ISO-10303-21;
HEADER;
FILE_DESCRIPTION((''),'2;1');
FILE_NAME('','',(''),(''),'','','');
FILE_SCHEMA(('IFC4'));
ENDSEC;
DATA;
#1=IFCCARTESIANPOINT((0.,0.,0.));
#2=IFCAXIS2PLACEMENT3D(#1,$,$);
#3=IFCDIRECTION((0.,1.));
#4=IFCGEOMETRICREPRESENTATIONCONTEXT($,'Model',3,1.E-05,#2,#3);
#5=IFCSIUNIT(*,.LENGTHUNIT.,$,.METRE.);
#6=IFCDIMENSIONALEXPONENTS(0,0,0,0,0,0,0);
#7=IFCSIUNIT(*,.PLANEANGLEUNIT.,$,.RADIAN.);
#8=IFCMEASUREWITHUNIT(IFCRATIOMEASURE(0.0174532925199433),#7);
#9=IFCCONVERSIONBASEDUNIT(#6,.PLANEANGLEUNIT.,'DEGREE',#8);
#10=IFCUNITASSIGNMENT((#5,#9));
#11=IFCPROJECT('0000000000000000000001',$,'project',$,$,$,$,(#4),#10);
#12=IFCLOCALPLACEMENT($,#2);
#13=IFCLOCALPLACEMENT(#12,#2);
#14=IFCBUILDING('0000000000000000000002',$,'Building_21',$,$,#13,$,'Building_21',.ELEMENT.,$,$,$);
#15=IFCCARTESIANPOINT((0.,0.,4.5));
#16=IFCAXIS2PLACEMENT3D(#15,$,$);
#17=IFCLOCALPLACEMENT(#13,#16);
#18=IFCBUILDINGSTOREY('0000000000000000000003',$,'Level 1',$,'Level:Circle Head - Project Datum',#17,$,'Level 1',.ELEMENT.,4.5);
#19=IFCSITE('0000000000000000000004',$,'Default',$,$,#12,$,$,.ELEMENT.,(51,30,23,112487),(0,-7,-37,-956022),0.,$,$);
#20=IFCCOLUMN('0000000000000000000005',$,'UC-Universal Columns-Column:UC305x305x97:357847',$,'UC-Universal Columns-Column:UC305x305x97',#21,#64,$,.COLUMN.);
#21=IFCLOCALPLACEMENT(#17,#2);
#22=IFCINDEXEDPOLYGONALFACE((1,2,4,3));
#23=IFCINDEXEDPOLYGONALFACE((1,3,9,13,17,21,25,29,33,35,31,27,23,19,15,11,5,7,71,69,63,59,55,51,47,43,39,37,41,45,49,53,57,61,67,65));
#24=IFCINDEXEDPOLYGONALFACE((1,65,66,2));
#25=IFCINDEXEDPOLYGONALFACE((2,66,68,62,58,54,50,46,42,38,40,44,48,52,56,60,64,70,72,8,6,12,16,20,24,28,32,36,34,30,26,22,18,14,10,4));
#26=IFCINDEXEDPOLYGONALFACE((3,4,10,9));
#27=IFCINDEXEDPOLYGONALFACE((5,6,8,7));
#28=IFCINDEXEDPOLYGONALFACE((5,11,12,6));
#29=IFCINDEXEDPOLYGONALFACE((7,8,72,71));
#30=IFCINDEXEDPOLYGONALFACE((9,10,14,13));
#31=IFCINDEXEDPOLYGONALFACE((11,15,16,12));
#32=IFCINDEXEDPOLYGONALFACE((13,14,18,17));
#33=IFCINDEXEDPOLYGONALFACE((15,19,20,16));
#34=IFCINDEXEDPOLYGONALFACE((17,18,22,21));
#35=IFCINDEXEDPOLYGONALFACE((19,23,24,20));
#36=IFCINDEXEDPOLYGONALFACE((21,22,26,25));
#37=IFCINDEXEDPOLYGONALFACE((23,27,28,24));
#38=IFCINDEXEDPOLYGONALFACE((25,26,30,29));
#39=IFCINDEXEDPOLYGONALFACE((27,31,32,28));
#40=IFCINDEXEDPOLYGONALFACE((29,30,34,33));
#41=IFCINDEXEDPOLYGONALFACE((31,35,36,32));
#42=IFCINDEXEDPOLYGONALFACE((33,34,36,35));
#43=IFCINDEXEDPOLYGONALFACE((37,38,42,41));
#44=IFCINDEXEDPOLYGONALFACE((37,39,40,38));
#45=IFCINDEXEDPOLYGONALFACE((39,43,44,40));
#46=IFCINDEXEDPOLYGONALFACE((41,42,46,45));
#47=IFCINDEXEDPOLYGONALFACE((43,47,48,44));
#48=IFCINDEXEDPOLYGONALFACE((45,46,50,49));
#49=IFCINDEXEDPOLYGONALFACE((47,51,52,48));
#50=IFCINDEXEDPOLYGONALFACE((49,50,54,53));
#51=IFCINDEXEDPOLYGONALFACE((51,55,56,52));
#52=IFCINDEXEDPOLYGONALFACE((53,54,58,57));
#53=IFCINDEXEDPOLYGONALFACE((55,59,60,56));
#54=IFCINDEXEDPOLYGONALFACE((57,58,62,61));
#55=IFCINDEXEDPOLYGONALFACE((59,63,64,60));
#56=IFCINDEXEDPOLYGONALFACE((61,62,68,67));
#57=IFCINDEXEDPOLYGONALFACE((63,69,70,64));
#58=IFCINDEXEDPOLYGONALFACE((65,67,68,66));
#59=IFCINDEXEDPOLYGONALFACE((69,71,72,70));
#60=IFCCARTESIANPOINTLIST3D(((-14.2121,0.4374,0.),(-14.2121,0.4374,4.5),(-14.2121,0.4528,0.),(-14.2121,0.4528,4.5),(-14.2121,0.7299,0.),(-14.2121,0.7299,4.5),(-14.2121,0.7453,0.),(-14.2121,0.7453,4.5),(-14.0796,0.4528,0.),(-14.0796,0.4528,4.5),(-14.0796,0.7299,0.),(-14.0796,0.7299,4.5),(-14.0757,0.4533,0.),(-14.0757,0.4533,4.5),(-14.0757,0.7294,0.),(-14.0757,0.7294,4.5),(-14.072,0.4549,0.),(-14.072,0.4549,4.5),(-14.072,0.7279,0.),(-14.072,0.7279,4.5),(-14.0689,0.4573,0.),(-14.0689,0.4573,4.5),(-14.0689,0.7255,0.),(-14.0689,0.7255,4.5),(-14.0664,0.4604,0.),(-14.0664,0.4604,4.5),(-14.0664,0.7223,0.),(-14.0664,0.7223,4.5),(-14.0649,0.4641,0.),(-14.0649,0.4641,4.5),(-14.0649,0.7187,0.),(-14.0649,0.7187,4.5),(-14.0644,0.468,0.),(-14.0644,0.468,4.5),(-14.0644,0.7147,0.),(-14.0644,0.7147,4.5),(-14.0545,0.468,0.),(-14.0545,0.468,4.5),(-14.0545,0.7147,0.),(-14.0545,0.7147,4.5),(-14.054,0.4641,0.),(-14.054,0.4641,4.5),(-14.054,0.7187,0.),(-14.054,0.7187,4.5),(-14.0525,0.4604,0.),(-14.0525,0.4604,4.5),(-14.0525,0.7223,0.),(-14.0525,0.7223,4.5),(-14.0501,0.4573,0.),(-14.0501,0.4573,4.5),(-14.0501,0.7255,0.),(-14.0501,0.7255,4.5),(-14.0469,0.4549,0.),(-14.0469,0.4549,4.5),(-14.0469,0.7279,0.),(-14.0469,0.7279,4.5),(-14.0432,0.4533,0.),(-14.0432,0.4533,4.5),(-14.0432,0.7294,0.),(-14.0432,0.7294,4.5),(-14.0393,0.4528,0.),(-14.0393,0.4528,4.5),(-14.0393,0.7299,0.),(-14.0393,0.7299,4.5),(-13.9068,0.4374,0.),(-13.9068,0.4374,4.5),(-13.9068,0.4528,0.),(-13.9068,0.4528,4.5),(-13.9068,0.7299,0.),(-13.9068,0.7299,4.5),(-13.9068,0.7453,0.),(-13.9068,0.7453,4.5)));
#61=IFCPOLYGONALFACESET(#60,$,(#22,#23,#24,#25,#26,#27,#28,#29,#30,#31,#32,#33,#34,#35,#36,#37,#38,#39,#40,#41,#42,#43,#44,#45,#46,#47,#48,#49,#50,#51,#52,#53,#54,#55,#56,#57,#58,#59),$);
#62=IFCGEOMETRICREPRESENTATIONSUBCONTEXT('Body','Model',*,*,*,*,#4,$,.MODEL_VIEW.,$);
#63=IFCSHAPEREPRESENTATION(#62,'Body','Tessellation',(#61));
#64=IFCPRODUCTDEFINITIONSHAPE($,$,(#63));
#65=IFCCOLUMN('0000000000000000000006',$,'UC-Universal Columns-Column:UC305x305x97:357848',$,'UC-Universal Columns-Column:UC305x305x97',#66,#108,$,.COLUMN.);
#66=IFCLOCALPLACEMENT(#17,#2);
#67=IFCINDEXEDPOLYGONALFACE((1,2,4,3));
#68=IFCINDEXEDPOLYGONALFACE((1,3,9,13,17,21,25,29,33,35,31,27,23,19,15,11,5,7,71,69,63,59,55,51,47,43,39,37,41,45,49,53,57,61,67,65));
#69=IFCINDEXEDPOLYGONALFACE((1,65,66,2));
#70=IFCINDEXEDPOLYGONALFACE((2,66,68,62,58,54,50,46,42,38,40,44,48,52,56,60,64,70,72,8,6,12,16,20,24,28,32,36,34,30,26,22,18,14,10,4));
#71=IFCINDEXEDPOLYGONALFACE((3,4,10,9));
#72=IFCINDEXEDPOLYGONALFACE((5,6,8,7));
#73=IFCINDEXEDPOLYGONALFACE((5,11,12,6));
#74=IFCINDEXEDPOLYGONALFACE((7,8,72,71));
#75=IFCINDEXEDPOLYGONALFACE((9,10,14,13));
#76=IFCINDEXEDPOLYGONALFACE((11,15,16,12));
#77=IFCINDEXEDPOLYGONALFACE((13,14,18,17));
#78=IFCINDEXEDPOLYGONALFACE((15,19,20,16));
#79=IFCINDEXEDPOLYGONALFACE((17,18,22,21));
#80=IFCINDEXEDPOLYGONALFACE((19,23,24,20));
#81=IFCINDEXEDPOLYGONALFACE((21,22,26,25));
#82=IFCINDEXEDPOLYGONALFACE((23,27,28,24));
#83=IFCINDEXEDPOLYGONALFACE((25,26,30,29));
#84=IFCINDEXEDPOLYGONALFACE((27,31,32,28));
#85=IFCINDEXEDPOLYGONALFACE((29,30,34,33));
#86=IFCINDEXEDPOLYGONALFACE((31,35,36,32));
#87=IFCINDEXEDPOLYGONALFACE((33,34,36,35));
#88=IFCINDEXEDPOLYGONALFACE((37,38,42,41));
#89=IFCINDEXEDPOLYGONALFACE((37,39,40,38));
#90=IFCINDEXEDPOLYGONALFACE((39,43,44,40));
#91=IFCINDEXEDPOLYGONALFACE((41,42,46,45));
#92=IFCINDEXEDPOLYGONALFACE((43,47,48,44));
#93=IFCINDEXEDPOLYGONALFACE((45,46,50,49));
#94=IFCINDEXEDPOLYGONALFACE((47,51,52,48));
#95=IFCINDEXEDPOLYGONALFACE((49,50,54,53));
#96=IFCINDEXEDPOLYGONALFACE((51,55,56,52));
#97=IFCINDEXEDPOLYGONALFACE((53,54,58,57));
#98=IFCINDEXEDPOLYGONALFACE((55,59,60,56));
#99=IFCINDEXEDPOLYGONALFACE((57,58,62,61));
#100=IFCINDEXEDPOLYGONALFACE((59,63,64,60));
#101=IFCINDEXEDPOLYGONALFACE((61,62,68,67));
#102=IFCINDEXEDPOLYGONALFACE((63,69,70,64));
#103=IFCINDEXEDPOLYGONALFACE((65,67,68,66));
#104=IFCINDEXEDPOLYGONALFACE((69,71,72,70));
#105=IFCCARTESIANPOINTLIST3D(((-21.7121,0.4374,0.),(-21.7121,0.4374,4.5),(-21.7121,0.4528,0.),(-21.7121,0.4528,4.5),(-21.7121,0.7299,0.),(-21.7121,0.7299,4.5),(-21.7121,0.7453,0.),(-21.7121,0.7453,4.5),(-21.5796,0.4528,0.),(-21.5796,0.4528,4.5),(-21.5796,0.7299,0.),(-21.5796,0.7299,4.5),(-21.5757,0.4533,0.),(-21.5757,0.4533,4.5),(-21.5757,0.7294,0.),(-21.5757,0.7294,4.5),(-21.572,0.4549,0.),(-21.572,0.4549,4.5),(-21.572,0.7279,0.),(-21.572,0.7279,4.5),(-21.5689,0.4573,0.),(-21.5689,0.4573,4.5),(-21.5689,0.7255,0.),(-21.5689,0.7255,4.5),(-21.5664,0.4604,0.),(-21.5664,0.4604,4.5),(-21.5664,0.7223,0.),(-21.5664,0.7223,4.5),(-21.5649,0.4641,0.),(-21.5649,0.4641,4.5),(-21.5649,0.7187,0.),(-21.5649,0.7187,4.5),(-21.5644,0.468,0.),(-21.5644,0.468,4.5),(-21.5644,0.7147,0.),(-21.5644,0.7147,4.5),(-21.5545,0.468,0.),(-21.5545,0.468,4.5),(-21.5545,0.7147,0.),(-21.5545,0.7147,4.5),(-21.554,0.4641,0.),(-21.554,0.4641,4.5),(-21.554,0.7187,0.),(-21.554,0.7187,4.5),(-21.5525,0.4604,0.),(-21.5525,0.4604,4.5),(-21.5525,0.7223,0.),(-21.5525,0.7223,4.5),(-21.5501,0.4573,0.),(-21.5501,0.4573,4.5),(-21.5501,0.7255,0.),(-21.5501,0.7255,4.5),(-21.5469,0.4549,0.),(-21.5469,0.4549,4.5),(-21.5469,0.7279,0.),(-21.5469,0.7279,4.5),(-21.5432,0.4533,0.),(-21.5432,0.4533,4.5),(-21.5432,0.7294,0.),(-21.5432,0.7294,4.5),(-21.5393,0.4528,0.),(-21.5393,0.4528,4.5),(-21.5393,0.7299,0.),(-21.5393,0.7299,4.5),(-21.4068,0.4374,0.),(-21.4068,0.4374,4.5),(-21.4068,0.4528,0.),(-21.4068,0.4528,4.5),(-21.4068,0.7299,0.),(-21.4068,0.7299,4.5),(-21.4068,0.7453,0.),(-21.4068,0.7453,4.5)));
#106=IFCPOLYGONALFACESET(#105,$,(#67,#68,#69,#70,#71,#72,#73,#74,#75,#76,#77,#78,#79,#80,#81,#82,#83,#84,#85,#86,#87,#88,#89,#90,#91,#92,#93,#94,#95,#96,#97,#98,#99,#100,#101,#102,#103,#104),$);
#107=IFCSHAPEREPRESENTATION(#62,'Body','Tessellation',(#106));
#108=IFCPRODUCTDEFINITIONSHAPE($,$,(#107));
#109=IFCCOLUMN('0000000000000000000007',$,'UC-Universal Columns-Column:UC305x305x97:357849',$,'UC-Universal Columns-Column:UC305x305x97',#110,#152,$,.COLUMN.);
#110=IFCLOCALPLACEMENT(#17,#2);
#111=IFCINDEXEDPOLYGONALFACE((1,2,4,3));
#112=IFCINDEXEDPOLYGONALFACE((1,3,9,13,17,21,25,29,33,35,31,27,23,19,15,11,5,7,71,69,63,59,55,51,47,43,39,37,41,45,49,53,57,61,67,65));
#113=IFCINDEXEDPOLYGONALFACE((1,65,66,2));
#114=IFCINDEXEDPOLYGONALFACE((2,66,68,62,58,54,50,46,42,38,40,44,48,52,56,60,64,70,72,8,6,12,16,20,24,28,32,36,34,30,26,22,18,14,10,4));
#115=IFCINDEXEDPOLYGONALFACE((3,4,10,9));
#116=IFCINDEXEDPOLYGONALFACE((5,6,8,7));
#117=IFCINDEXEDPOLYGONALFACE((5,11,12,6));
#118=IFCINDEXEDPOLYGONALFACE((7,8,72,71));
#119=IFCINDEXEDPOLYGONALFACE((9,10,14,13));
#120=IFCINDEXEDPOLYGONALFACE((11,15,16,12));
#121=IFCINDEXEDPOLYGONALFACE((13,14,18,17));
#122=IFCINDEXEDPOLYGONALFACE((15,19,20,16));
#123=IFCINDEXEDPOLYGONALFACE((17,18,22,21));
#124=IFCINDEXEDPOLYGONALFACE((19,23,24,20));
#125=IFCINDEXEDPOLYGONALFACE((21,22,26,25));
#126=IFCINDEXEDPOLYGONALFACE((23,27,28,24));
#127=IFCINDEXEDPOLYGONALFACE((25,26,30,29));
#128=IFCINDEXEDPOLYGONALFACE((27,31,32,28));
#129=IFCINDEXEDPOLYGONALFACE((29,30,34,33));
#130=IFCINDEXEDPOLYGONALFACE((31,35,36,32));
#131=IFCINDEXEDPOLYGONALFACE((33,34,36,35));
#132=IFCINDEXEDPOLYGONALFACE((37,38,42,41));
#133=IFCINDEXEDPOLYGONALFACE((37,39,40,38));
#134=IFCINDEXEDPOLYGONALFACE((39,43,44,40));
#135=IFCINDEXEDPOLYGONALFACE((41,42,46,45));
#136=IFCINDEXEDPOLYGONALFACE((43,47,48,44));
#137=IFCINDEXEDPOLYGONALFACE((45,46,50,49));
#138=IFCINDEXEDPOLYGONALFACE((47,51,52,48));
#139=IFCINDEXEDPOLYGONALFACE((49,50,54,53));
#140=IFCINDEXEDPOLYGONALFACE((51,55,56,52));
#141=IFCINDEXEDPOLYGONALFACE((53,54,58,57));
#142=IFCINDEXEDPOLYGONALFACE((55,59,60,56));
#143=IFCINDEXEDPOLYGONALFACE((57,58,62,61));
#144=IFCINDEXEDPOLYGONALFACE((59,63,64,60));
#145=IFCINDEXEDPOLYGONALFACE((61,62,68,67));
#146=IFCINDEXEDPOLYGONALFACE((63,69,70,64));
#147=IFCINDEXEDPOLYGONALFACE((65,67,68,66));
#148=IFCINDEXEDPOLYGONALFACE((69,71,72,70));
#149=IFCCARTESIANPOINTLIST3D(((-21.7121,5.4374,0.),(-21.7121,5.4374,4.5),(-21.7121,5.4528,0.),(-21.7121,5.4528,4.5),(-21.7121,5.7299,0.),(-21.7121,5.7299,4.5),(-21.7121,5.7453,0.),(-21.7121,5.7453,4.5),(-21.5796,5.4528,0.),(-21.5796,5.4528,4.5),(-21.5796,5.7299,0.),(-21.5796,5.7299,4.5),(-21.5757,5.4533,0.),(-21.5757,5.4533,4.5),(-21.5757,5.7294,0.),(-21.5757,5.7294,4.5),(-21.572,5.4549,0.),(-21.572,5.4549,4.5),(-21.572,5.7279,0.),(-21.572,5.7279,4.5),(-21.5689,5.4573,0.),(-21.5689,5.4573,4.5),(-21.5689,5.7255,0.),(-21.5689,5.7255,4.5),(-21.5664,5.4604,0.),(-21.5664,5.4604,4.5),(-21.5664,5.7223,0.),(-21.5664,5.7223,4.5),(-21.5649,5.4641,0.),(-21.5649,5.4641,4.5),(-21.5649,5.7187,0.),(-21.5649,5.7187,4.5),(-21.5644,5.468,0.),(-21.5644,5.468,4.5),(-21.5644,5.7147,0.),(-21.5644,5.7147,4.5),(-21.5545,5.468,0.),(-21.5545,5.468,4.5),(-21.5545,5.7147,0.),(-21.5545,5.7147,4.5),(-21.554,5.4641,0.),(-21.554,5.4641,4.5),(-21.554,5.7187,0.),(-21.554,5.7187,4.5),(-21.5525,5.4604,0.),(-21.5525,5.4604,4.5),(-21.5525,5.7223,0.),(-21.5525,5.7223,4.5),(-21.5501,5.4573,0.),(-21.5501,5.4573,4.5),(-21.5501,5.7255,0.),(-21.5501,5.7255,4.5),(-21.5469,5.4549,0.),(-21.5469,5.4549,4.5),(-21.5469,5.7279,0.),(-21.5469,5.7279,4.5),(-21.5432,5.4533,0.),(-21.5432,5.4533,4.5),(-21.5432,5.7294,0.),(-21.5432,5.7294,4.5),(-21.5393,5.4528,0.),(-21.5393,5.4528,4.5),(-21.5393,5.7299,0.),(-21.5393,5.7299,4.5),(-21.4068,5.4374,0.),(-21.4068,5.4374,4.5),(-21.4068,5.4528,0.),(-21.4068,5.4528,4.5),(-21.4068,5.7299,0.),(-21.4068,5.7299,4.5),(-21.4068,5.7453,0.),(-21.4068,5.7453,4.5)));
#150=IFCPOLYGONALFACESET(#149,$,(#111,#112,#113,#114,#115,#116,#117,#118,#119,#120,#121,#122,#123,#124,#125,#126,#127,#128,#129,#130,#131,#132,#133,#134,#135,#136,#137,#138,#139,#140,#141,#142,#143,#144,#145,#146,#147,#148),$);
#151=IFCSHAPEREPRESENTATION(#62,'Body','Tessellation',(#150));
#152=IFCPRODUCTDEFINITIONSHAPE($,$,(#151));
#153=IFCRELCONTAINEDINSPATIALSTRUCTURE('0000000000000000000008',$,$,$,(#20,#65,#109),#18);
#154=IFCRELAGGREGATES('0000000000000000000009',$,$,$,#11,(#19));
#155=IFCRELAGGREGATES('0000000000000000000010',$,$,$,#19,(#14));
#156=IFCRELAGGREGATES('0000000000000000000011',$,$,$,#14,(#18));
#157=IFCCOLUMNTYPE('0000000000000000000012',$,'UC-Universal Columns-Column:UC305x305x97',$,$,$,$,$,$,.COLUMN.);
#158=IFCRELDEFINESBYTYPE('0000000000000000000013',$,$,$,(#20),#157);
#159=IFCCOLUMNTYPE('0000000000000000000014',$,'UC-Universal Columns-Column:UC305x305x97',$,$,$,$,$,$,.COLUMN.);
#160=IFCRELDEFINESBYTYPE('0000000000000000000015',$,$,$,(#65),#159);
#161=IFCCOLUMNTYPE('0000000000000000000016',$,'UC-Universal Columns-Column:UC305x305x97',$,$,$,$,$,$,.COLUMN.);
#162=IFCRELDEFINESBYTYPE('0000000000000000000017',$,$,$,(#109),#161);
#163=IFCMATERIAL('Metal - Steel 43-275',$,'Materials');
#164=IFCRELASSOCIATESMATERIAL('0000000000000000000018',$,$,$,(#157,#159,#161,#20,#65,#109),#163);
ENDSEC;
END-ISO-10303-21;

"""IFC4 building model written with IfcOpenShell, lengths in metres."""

from ifc_helpers import new_model, entity, si_unit, converted_unit, direction, frame, frame_2d, origin, place, context, subcontext, project, spatial, polyline, circle_curve, parameter, trimmed, segment, composite_curve, i_section, outline, extrude, source, transform, mapped, material, material_profile, profile_set, profile_usage, type_object, type_shapes, element, save


model = new_model("IFC4")

# Units and contexts
model_context = context("Model", 3, precision=1e-05, world=origin(), true_north=direction((0.0, 1.0)))
body_context = subcontext(model_context, "Body", "Model", "MODEL_VIEW")
ifc_project = project(units=[si_unit("LENGTHUNIT", "METRE"), converted_unit("PLANEANGLEUNIT", "DEGREE", entity("IfcRatioMeasure", 0.0174532925199433), si_unit("PLANEANGLEUNIT", "RADIAN"), dimensions=[0, 0, 0, 0, 0, 0, 0])], contexts=[model_context])

# Site, building, storey
site_placement = place(None, origin())
site = spatial("IfcSite", under=ifc_project, at=site_placement, Name="Default", CompositionType="ELEMENT", RefLatitude=(51, 30, 23, 112487), RefLongitude=(0, -7, -37, -956022), RefElevation=0.0)
building_placement = place(site_placement, origin())
building = spatial("IfcBuilding", under=site, at=building_placement, Name="Building_21", LongName="Building_21", CompositionType="ELEMENT")
storey_placement = place(building_placement, frame((0.0, 0.0, 4.5)))
storey = spatial("IfcBuildingStorey", under=building, at=storey_placement, Name="Level 1", ObjectType="Level:Circle Head - Project Datum", LongName="Level 1", CompositionType="ELEMENT", Elevation=4.5)

# Columns
ifc_material_1 = material(Name="Metal - Steel 43-275", Category="Materials")
ifc_material_profile_1 = material_profile(ifc_material_1, outline(composite_curve([segment(polyline([(-0.1527, 0.154, 0.0), (0.1527, 0.154, 0.0)]), True, "CONTINUOUS"), segment(polyline([(0.1527, 0.154, 0.0), (0.1527, 0.1386, 0.0)]), True, "CONTINUOUS"), segment(polyline([(0.1527, 0.1386, 0.0), (0.0201, 0.1386, 0.0)]), True, "CONTINUOUS"), segment(trimmed(circle_curve(frame((0.0201, 0.1234, 0.0)), 0.0152), [parameter(90.0)], [parameter(180.0)], True, "PARAMETER"), True, "CONTINUOUS"), segment(polyline([(0.0049, 0.1234, 0.0), (0.0049, -0.1234, 0.0)]), True, "CONTINUOUS"), segment(trimmed(circle_curve(frame((0.0201, -0.1234, 0.0)), 0.0152), [parameter(180.0)], [parameter(270.0)], True, "PARAMETER"), True, "CONTINUOUS"), segment(polyline([(0.0201, -0.1386, 0.0), (0.1527, -0.1386, 0.0)]), True, "CONTINUOUS"), segment(polyline([(0.1527, -0.1386, 0.0), (0.1527, -0.154, 0.0)]), True, "CONTINUOUS"), segment(polyline([(0.1527, -0.154, 0.0), (-0.1527, -0.154, 0.0)]), True, "CONTINUOUS"), segment(polyline([(-0.1527, -0.154, 0.0), (-0.1527, -0.1386, 0.0)]), True, "CONTINUOUS"), segment(polyline([(-0.1527, -0.1386, 0.0), (-0.0201, -0.1386, 0.0)]), True, "CONTINUOUS"), segment(trimmed(circle_curve(frame((-0.0201, -0.1234, 0.0)), 0.0152), [parameter(270.0)], [parameter(0.0)], True, "PARAMETER"), True, "CONTINUOUS"), segment(polyline([(-0.0049, -0.1234, 0.0), (-0.005, 0.1234, 0.0)]), True, "CONTINUOUS"), segment(trimmed(circle_curve(frame((-0.0201, 0.1234, 0.0)), 0.0152), [parameter(0.0)], [parameter(90.0)], True, "PARAMETER"), True, "CONTINUOUS"), segment(polyline([(-0.0201, 0.1386, 0.0), (-0.1527, 0.1386, 0.0)]), True, "CONTINUOUS"), segment(polyline([(-0.1527, 0.1386, 0.0), (-0.1527, 0.154, 0.0)]), True, "CONTINUOUS")], self_intersect=False), kind="CURVE"), Name="UC305x305x97")
ifc_material_profile_2 = material_profile(ifc_material_1, outline(composite_curve([segment(polyline([(0.1527, 0.154, 0.0), (0.1527, 0.1386, 0.0)]), True, "CONTINUOUS"), segment(polyline([(0.1527, 0.1386, 0.0), (0.0049, 0.1386, 0.0)]), True, "CONTINUOUS"), segment(polyline([(0.0049, 0.1386, 0.0), (0.0049, -0.1386, 0.0)]), True, "CONTINUOUS"), segment(polyline([(0.0049, -0.1386, 0.0), (0.1527, -0.1386, 0.0)]), True, "CONTINUOUS"), segment(polyline([(0.1527, -0.1386, 0.0), (0.1527, -0.154, 0.0)]), True, "CONTINUOUS"), segment(polyline([(0.1527, -0.154, 0.0), (-0.1527, -0.154, 0.0)]), True, "CONTINUOUS"), segment(polyline([(-0.1527, -0.154, 0.0), (-0.1527, -0.1386, 0.0)]), True, "CONTINUOUS"), segment(polyline([(-0.1527, -0.1386, 0.0), (-0.005, -0.1386, 0.0)]), True, "CONTINUOUS"), segment(polyline([(-0.005, -0.1386, 0.0), (-0.005, 0.1386, 0.0)]), True, "CONTINUOUS"), segment(polyline([(-0.005, 0.1386, 0.0), (-0.1527, 0.1386, 0.0)]), True, "CONTINUOUS"), segment(polyline([(-0.1527, 0.1386, 0.0), (-0.1527, 0.154, 0.0)]), True, "CONTINUOUS"), segment(polyline([(-0.1527, 0.154, 0.0), (0.1527, 0.154, 0.0)]), True, "CONTINUOUS")], self_intersect=False), kind="CURVE"), Name="UC305x305x97")
ifc_profile_set_1 = profile_set([ifc_material_profile_1, ifc_material_profile_2], Name="UC305x305x97")
ifc_profile_usage_1 = profile_usage(ifc_profile_set_1)
column_type_1 = type_object("IfcColumnType", Name="UC-Universal Columns-Column:UC305x305x97", PredefinedType="COLUMN", material=ifc_profile_set_1)
shared_shape_1 = source(origin(), body_context, "Body", "SweptSolid", [
    extrude(i_section(OverallWidth=0.3053, OverallDepth=0.3079, WebThickness=0.0099, FlangeThickness=0.0154, FilletRadius=0.0152, at=frame_2d((0.0, 0.0), x_axis=(0.0, 1.0))), frame((-14.0595, 0.5914, 4.5), z_axis=(0.0, 0.0, 1.0), x_axis=(0.0, -1.0, 0.0)), (0.0, 0.0, 1.0), 4.5),
])
type_shapes(column_type_1, [shared_shape_1])
column_1_placement = place(storey_placement, frame((0.0, 0.0, -4.5)))
element("IfcColumn", 1, at=column_1_placement, inside=storey, type_object=column_type_1, material=ifc_profile_usage_1, Name="UC-Universal Columns-Column:UC305x305x97:357847", ObjectType="UC-Universal Columns-Column:UC305x305x97", PredefinedType="COLUMN", context=body_context, shape_type="MappedRepresentation", body=[
    mapped(shared_shape_1, transform((0.0, 0.0, 0.0), scale=1.0)),
])
ifc_profile_usage_2 = profile_usage(ifc_profile_set_1)
column_type_2 = type_object("IfcColumnType", Name="UC-Universal Columns-Column:UC305x305x97", PredefinedType="COLUMN", material=ifc_profile_set_1)
shared_shape_2 = source(origin(), body_context, "Body", "SweptSolid", [
    extrude(i_section(OverallWidth=0.3053, OverallDepth=0.3079, WebThickness=0.0099, FlangeThickness=0.0154, FilletRadius=0.0152, at=frame_2d((0.0, 0.0), x_axis=(0.0, 1.0))), frame((-21.5595, 0.5914, 4.5), z_axis=(0.0, 0.0, 1.0), x_axis=(0.0, -1.0, 0.0)), (0.0, 0.0, 1.0), 4.5),
])
type_shapes(column_type_2, [shared_shape_2])
column_2_placement = place(storey_placement, frame((0.0, 0.0, -4.5)))
element("IfcColumn", 2, at=column_2_placement, inside=storey, type_object=column_type_2, material=ifc_profile_usage_2, Name="UC-Universal Columns-Column:UC305x305x97:357848", ObjectType="UC-Universal Columns-Column:UC305x305x97", PredefinedType="COLUMN", context=body_context, shape_type="MappedRepresentation", body=[
    mapped(shared_shape_2, transform((0.0, 0.0, 0.0), scale=1.0)),
])
ifc_profile_usage_3 = profile_usage(ifc_profile_set_1)
column_type_3 = type_object("IfcColumnType", Name="UC-Universal Columns-Column:UC305x305x97", PredefinedType="COLUMN", material=ifc_profile_set_1)
shared_shape_3 = source(origin(), body_context, "Body", "SweptSolid", [
    extrude(i_section(OverallWidth=0.3053, OverallDepth=0.3079, WebThickness=0.0099, FlangeThickness=0.0154, FilletRadius=0.0152, at=frame_2d((0.0, 0.0), x_axis=(0.0, 1.0))), frame((-21.5595, 5.5914, 4.5), z_axis=(0.0, 0.0, 1.0), x_axis=(0.0, -1.0, 0.0)), (0.0, 0.0, 1.0), 4.5),
])
type_shapes(column_type_3, [shared_shape_3])
column_3_placement = place(storey_placement, frame((0.0, 0.0, -4.5)))
element("IfcColumn", 3, at=column_3_placement, inside=storey, type_object=column_type_3, material=ifc_profile_usage_3, Name="UC-Universal Columns-Column:UC305x305x97:357849", ObjectType="UC-Universal Columns-Column:UC305x305x97", PredefinedType="COLUMN", context=body_context, shape_type="MappedRepresentation", body=[
    mapped(shared_shape_3, transform((0.0, 0.0, 0.0), scale=1.0)),
])

save(model, "model.ifc")
